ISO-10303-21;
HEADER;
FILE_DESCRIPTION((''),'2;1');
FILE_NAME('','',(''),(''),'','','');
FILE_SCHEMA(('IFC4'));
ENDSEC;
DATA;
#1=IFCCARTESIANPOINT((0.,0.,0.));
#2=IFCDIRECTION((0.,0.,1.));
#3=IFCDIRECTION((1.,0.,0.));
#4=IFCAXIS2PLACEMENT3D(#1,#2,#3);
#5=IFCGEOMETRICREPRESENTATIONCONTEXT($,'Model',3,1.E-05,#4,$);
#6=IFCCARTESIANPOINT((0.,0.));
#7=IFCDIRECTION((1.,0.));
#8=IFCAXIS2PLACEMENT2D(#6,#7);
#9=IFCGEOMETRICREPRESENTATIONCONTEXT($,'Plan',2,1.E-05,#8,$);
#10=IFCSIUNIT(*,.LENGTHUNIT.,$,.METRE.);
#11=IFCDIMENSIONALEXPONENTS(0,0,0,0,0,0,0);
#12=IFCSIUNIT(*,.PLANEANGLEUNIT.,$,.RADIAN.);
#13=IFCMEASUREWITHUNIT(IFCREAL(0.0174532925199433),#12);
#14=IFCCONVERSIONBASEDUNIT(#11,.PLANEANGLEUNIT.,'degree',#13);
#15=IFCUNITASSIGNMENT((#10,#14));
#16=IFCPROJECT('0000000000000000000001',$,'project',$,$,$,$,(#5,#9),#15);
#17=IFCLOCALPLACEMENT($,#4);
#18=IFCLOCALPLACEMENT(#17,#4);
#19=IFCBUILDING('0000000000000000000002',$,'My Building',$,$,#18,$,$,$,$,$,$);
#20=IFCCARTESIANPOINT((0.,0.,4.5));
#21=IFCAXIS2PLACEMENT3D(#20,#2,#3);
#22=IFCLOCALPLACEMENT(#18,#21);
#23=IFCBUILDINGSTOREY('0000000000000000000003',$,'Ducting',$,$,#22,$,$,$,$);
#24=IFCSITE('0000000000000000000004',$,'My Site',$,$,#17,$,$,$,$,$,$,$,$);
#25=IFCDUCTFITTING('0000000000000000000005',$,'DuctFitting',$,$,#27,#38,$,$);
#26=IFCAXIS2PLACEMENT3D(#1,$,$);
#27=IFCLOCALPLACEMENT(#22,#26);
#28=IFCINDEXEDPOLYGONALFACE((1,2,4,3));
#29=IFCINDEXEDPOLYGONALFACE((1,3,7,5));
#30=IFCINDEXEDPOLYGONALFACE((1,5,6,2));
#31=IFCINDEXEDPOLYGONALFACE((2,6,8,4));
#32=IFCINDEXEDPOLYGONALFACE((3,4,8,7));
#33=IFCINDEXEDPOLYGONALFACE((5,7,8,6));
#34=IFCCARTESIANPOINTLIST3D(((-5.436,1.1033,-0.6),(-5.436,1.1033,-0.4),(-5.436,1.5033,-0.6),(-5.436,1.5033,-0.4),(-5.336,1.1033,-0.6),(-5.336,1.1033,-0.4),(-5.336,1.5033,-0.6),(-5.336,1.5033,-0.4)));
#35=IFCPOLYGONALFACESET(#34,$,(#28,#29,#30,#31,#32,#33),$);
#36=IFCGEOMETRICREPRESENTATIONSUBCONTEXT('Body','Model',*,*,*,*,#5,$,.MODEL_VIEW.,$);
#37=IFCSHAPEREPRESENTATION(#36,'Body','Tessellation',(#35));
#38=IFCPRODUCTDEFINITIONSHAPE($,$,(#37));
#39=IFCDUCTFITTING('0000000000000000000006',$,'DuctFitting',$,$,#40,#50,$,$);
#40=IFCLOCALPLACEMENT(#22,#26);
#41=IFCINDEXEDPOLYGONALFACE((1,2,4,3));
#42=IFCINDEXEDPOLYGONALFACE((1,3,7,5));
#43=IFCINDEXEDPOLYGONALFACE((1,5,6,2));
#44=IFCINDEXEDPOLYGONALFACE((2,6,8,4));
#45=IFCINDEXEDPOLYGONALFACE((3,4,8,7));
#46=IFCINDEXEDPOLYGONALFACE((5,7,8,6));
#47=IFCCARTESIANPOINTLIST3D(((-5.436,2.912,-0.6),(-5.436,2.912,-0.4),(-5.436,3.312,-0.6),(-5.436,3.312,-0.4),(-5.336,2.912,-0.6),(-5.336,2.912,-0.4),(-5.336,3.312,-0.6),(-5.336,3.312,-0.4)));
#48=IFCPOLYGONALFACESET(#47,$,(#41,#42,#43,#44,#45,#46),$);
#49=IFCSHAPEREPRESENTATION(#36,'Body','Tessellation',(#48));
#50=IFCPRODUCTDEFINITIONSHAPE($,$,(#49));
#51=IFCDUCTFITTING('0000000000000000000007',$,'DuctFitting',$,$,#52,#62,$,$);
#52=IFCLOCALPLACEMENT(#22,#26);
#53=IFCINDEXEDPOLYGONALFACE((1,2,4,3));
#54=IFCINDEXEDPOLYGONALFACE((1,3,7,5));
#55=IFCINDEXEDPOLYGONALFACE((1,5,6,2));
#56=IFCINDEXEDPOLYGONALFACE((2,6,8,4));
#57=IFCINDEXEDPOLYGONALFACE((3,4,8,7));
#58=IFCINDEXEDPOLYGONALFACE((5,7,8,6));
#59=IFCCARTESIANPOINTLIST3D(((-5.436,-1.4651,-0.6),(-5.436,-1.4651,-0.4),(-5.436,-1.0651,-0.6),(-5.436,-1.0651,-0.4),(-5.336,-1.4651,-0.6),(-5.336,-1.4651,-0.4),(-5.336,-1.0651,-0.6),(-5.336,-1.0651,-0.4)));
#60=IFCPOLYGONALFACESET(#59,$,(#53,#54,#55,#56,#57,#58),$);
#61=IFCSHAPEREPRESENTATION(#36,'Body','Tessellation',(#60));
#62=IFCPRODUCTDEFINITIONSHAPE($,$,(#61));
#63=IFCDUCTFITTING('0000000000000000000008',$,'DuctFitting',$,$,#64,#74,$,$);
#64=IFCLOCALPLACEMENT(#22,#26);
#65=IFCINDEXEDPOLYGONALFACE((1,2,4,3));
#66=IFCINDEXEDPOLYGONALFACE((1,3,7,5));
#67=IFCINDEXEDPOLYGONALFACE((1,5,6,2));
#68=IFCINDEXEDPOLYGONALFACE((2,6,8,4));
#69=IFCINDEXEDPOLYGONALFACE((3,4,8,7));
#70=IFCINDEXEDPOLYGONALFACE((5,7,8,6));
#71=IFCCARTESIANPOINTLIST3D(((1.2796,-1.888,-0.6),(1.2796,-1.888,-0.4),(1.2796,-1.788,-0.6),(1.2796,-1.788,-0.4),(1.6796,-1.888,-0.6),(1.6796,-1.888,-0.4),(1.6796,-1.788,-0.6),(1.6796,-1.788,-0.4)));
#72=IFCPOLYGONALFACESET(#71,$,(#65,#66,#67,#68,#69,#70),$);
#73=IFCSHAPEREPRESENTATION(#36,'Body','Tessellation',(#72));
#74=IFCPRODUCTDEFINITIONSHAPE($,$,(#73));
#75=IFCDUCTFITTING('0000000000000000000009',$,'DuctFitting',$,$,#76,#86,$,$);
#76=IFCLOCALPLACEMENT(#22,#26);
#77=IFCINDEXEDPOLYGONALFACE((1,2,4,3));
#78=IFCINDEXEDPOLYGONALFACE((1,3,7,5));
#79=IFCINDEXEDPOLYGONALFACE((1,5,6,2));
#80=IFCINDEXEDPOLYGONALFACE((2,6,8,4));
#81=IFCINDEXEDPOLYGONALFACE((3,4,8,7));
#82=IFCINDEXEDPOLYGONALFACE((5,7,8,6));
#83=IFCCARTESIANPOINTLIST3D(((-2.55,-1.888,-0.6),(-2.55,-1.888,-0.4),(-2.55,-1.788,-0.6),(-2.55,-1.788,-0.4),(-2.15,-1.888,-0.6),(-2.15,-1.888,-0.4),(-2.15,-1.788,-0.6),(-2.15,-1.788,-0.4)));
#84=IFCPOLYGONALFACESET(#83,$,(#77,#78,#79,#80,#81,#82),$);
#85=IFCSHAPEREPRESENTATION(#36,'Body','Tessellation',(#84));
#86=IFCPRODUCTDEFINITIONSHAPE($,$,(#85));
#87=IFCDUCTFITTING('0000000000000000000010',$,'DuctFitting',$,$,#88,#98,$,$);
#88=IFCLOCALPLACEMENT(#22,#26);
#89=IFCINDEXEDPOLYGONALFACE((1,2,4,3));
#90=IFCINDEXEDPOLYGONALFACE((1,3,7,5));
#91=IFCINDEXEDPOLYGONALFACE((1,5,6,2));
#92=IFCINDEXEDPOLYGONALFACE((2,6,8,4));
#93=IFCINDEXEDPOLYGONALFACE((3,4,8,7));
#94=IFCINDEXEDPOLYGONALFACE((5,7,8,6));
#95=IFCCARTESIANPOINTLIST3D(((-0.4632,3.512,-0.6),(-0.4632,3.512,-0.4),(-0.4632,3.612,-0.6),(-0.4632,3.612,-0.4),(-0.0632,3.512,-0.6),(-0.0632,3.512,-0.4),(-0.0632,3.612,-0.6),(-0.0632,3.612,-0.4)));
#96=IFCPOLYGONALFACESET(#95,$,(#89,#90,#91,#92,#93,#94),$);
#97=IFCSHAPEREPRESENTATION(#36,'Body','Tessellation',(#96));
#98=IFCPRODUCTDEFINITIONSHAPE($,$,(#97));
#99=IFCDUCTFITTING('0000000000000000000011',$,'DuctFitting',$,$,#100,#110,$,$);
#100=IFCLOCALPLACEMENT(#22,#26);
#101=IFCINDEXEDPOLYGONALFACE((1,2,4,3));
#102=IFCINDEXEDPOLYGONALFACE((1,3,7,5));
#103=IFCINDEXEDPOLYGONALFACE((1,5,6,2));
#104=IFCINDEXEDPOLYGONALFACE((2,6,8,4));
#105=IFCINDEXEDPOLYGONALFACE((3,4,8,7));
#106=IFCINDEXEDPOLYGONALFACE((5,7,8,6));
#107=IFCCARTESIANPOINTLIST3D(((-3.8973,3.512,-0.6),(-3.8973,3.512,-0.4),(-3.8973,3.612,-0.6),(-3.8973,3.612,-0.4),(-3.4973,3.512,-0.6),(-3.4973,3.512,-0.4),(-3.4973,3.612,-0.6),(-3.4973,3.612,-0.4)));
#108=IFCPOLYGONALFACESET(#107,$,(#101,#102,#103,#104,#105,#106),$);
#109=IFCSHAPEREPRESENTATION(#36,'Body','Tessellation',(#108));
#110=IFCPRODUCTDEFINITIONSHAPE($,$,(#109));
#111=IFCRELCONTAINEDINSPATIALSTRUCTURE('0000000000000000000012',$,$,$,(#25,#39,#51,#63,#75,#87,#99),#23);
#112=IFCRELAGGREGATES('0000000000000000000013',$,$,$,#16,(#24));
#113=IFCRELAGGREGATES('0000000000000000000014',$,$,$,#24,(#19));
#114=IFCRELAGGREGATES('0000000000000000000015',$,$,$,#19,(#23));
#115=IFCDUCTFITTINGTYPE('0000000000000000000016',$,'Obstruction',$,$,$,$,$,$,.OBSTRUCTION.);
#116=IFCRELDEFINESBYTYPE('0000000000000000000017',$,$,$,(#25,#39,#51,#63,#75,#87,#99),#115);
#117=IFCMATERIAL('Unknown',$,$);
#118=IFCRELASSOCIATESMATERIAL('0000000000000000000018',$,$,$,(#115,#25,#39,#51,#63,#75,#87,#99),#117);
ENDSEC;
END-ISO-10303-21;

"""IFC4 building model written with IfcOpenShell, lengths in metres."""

from ifc_helpers import new_model, entity, si_unit, converted_unit, frame, origin_with_axes, origin_2d_with_axis, place, context, subcontext, project, spatial, rectangle, extrude, material, material_profile, profile_set, profile_usage, type_object, element, save


model = new_model("IFC4")

# Units and contexts
model_context = context("Model", 3, precision=1e-05, world=origin_with_axes())
plan_context = context("Plan", 2, precision=1e-05, world=origin_2d_with_axis())
body_context = subcontext(model_context, "Body", "Model", "MODEL_VIEW")
ifc_project = project(units=[si_unit("LENGTHUNIT", "METRE"), converted_unit("PLANEANGLEUNIT", "degree", entity("IfcReal", 0.0174532925199433), si_unit("PLANEANGLEUNIT", "RADIAN"), dimensions=[0, 0, 0, 0, 0, 0, 0])], contexts=[model_context, plan_context])

# Site, building, storey
site_placement = place(None, origin_with_axes())
site = spatial("IfcSite", under=ifc_project, at=site_placement, Name="My Site")
building_placement = place(site_placement, origin_with_axes())
building = spatial("IfcBuilding", under=site, at=building_placement, Name="My Building")
storey_placement = place(building_placement, frame((0.0, 0.0, 4.5), z_axis=(0.0, 0.0, 1.0), x_axis=(1.0, 0.0, 0.0)))
storey = spatial("IfcBuildingStorey", under=building, at=storey_placement, Name="Ducting")

# Shared definitions
ifc_material = material(Name="Unknown")

# Duct fittings
ifc_material_profile_1 = material_profile(ifc_material, rectangle(XDim=0.4, YDim=0.2))
ifc_profile_set_1 = profile_set([ifc_material_profile_1])
duct_fitting_type_1 = type_object("IfcDuctFittingType", Name="Obstruction", PredefinedType="OBSTRUCTION", material=ifc_profile_set_1)
ifc_profile_usage_1 = profile_usage(ifc_profile_set_1, cardinal=5)
duct_fitting_1_placement = place(storey_placement, frame((-5.336, 1.3033, -0.5), z_axis=(-1.0, 0.0, 0.0), x_axis=(0.0, -1.0, 0.0)))
element("IfcDuctFitting", 1, at=duct_fitting_1_placement, inside=storey, type_object=duct_fitting_type_1, material=ifc_profile_usage_1, Name="DuctFitting", context=body_context, shape_type="SweptSolid", body=[
    extrude(rectangle(XDim=0.4, YDim=0.2), origin_with_axes(), (0.0, 0.0, 1.0), 0.1),
])
ifc_profile_usage_2 = profile_usage(ifc_profile_set_1, cardinal=5)
duct_fitting_2_placement = place(storey_placement, frame((-5.336, 3.112, -0.5), z_axis=(-1.0, 0.0, 0.0), x_axis=(0.0, -1.0, 0.0)))
element("IfcDuctFitting", 2, at=duct_fitting_2_placement, inside=storey, type_object=duct_fitting_type_1, material=ifc_profile_usage_2, Name="DuctFitting", context=body_context, shape_type="SweptSolid", body=[
    extrude(rectangle(XDim=0.4, YDim=0.2), origin_with_axes(), (0.0, 0.0, 1.0), 0.1),
])
ifc_profile_usage_3 = profile_usage(ifc_profile_set_1, cardinal=5)
duct_fitting_3_placement = place(storey_placement, frame((-5.336, -1.2651, -0.5), z_axis=(-1.0, 0.0, 0.0), x_axis=(0.0, -1.0, 0.0)))
element("IfcDuctFitting", 3, at=duct_fitting_3_placement, inside=storey, type_object=duct_fitting_type_1, material=ifc_profile_usage_3, Name="DuctFitting", context=body_context, shape_type="SweptSolid", body=[
    extrude(rectangle(XDim=0.4, YDim=0.2), origin_with_axes(), (0.0, 0.0, 1.0), 0.1),
])
ifc_profile_usage_4 = profile_usage(ifc_profile_set_1, cardinal=5)
duct_fitting_4_placement = place(storey_placement, frame((1.4796, -1.788, -0.5), z_axis=(0.0, -1.0, 0.000004), x_axis=(1.0, 0.0, 0.0)))
element("IfcDuctFitting", 4, at=duct_fitting_4_placement, inside=storey, type_object=duct_fitting_type_1, material=ifc_profile_usage_4, Name="DuctFitting", context=body_context, shape_type="SweptSolid", body=[
    extrude(rectangle(XDim=0.4, YDim=0.2), origin_with_axes(), (0.0, 0.0, 1.0), 0.1),
])
ifc_profile_usage_5 = profile_usage(ifc_profile_set_1, cardinal=5)
duct_fitting_5_placement = place(storey_placement, frame((-2.35, -1.788, -0.5), z_axis=(0.0, -1.0, 0.000004), x_axis=(1.0, 0.0, 0.0)))
element("IfcDuctFitting", 5, at=duct_fitting_5_placement, inside=storey, type_object=duct_fitting_type_1, material=ifc_profile_usage_5, Name="DuctFitting", context=body_context, shape_type="SweptSolid", body=[
    extrude(rectangle(XDim=0.4, YDim=0.2), origin_with_axes(), (0.0, 0.0, 1.0), 0.1),
])
ifc_profile_usage_6 = profile_usage(ifc_profile_set_1, cardinal=5)
duct_fitting_6_placement = place(storey_placement, frame((-0.2632, 3.512, -0.5), z_axis=(0.0, 1.0, 0.000013), x_axis=(-1.0, 0.0, 0.0)))
element("IfcDuctFitting", 6, at=duct_fitting_6_placement, inside=storey, type_object=duct_fitting_type_1, material=ifc_profile_usage_6, Name="DuctFitting", context=body_context, shape_type="SweptSolid", body=[
    extrude(rectangle(XDim=0.4, YDim=0.2), origin_with_axes(), (0.0, 0.0, 1.0), 0.1),
])
ifc_profile_usage_7 = profile_usage(ifc_profile_set_1, cardinal=5)
duct_fitting_7_placement = place(storey_placement, frame((-3.6973, 3.512, -0.5), z_axis=(0.0, 1.0, 0.000013), x_axis=(-1.0, 0.0, 0.0)))
element("IfcDuctFitting", 7, at=duct_fitting_7_placement, inside=storey, type_object=duct_fitting_type_1, material=ifc_profile_usage_7, Name="DuctFitting", context=body_context, shape_type="SweptSolid", body=[
    extrude(rectangle(XDim=0.4, YDim=0.2), origin_with_axes(), (0.0, 0.0, 1.0), 0.1),
])

save(model, "model.ifc")
